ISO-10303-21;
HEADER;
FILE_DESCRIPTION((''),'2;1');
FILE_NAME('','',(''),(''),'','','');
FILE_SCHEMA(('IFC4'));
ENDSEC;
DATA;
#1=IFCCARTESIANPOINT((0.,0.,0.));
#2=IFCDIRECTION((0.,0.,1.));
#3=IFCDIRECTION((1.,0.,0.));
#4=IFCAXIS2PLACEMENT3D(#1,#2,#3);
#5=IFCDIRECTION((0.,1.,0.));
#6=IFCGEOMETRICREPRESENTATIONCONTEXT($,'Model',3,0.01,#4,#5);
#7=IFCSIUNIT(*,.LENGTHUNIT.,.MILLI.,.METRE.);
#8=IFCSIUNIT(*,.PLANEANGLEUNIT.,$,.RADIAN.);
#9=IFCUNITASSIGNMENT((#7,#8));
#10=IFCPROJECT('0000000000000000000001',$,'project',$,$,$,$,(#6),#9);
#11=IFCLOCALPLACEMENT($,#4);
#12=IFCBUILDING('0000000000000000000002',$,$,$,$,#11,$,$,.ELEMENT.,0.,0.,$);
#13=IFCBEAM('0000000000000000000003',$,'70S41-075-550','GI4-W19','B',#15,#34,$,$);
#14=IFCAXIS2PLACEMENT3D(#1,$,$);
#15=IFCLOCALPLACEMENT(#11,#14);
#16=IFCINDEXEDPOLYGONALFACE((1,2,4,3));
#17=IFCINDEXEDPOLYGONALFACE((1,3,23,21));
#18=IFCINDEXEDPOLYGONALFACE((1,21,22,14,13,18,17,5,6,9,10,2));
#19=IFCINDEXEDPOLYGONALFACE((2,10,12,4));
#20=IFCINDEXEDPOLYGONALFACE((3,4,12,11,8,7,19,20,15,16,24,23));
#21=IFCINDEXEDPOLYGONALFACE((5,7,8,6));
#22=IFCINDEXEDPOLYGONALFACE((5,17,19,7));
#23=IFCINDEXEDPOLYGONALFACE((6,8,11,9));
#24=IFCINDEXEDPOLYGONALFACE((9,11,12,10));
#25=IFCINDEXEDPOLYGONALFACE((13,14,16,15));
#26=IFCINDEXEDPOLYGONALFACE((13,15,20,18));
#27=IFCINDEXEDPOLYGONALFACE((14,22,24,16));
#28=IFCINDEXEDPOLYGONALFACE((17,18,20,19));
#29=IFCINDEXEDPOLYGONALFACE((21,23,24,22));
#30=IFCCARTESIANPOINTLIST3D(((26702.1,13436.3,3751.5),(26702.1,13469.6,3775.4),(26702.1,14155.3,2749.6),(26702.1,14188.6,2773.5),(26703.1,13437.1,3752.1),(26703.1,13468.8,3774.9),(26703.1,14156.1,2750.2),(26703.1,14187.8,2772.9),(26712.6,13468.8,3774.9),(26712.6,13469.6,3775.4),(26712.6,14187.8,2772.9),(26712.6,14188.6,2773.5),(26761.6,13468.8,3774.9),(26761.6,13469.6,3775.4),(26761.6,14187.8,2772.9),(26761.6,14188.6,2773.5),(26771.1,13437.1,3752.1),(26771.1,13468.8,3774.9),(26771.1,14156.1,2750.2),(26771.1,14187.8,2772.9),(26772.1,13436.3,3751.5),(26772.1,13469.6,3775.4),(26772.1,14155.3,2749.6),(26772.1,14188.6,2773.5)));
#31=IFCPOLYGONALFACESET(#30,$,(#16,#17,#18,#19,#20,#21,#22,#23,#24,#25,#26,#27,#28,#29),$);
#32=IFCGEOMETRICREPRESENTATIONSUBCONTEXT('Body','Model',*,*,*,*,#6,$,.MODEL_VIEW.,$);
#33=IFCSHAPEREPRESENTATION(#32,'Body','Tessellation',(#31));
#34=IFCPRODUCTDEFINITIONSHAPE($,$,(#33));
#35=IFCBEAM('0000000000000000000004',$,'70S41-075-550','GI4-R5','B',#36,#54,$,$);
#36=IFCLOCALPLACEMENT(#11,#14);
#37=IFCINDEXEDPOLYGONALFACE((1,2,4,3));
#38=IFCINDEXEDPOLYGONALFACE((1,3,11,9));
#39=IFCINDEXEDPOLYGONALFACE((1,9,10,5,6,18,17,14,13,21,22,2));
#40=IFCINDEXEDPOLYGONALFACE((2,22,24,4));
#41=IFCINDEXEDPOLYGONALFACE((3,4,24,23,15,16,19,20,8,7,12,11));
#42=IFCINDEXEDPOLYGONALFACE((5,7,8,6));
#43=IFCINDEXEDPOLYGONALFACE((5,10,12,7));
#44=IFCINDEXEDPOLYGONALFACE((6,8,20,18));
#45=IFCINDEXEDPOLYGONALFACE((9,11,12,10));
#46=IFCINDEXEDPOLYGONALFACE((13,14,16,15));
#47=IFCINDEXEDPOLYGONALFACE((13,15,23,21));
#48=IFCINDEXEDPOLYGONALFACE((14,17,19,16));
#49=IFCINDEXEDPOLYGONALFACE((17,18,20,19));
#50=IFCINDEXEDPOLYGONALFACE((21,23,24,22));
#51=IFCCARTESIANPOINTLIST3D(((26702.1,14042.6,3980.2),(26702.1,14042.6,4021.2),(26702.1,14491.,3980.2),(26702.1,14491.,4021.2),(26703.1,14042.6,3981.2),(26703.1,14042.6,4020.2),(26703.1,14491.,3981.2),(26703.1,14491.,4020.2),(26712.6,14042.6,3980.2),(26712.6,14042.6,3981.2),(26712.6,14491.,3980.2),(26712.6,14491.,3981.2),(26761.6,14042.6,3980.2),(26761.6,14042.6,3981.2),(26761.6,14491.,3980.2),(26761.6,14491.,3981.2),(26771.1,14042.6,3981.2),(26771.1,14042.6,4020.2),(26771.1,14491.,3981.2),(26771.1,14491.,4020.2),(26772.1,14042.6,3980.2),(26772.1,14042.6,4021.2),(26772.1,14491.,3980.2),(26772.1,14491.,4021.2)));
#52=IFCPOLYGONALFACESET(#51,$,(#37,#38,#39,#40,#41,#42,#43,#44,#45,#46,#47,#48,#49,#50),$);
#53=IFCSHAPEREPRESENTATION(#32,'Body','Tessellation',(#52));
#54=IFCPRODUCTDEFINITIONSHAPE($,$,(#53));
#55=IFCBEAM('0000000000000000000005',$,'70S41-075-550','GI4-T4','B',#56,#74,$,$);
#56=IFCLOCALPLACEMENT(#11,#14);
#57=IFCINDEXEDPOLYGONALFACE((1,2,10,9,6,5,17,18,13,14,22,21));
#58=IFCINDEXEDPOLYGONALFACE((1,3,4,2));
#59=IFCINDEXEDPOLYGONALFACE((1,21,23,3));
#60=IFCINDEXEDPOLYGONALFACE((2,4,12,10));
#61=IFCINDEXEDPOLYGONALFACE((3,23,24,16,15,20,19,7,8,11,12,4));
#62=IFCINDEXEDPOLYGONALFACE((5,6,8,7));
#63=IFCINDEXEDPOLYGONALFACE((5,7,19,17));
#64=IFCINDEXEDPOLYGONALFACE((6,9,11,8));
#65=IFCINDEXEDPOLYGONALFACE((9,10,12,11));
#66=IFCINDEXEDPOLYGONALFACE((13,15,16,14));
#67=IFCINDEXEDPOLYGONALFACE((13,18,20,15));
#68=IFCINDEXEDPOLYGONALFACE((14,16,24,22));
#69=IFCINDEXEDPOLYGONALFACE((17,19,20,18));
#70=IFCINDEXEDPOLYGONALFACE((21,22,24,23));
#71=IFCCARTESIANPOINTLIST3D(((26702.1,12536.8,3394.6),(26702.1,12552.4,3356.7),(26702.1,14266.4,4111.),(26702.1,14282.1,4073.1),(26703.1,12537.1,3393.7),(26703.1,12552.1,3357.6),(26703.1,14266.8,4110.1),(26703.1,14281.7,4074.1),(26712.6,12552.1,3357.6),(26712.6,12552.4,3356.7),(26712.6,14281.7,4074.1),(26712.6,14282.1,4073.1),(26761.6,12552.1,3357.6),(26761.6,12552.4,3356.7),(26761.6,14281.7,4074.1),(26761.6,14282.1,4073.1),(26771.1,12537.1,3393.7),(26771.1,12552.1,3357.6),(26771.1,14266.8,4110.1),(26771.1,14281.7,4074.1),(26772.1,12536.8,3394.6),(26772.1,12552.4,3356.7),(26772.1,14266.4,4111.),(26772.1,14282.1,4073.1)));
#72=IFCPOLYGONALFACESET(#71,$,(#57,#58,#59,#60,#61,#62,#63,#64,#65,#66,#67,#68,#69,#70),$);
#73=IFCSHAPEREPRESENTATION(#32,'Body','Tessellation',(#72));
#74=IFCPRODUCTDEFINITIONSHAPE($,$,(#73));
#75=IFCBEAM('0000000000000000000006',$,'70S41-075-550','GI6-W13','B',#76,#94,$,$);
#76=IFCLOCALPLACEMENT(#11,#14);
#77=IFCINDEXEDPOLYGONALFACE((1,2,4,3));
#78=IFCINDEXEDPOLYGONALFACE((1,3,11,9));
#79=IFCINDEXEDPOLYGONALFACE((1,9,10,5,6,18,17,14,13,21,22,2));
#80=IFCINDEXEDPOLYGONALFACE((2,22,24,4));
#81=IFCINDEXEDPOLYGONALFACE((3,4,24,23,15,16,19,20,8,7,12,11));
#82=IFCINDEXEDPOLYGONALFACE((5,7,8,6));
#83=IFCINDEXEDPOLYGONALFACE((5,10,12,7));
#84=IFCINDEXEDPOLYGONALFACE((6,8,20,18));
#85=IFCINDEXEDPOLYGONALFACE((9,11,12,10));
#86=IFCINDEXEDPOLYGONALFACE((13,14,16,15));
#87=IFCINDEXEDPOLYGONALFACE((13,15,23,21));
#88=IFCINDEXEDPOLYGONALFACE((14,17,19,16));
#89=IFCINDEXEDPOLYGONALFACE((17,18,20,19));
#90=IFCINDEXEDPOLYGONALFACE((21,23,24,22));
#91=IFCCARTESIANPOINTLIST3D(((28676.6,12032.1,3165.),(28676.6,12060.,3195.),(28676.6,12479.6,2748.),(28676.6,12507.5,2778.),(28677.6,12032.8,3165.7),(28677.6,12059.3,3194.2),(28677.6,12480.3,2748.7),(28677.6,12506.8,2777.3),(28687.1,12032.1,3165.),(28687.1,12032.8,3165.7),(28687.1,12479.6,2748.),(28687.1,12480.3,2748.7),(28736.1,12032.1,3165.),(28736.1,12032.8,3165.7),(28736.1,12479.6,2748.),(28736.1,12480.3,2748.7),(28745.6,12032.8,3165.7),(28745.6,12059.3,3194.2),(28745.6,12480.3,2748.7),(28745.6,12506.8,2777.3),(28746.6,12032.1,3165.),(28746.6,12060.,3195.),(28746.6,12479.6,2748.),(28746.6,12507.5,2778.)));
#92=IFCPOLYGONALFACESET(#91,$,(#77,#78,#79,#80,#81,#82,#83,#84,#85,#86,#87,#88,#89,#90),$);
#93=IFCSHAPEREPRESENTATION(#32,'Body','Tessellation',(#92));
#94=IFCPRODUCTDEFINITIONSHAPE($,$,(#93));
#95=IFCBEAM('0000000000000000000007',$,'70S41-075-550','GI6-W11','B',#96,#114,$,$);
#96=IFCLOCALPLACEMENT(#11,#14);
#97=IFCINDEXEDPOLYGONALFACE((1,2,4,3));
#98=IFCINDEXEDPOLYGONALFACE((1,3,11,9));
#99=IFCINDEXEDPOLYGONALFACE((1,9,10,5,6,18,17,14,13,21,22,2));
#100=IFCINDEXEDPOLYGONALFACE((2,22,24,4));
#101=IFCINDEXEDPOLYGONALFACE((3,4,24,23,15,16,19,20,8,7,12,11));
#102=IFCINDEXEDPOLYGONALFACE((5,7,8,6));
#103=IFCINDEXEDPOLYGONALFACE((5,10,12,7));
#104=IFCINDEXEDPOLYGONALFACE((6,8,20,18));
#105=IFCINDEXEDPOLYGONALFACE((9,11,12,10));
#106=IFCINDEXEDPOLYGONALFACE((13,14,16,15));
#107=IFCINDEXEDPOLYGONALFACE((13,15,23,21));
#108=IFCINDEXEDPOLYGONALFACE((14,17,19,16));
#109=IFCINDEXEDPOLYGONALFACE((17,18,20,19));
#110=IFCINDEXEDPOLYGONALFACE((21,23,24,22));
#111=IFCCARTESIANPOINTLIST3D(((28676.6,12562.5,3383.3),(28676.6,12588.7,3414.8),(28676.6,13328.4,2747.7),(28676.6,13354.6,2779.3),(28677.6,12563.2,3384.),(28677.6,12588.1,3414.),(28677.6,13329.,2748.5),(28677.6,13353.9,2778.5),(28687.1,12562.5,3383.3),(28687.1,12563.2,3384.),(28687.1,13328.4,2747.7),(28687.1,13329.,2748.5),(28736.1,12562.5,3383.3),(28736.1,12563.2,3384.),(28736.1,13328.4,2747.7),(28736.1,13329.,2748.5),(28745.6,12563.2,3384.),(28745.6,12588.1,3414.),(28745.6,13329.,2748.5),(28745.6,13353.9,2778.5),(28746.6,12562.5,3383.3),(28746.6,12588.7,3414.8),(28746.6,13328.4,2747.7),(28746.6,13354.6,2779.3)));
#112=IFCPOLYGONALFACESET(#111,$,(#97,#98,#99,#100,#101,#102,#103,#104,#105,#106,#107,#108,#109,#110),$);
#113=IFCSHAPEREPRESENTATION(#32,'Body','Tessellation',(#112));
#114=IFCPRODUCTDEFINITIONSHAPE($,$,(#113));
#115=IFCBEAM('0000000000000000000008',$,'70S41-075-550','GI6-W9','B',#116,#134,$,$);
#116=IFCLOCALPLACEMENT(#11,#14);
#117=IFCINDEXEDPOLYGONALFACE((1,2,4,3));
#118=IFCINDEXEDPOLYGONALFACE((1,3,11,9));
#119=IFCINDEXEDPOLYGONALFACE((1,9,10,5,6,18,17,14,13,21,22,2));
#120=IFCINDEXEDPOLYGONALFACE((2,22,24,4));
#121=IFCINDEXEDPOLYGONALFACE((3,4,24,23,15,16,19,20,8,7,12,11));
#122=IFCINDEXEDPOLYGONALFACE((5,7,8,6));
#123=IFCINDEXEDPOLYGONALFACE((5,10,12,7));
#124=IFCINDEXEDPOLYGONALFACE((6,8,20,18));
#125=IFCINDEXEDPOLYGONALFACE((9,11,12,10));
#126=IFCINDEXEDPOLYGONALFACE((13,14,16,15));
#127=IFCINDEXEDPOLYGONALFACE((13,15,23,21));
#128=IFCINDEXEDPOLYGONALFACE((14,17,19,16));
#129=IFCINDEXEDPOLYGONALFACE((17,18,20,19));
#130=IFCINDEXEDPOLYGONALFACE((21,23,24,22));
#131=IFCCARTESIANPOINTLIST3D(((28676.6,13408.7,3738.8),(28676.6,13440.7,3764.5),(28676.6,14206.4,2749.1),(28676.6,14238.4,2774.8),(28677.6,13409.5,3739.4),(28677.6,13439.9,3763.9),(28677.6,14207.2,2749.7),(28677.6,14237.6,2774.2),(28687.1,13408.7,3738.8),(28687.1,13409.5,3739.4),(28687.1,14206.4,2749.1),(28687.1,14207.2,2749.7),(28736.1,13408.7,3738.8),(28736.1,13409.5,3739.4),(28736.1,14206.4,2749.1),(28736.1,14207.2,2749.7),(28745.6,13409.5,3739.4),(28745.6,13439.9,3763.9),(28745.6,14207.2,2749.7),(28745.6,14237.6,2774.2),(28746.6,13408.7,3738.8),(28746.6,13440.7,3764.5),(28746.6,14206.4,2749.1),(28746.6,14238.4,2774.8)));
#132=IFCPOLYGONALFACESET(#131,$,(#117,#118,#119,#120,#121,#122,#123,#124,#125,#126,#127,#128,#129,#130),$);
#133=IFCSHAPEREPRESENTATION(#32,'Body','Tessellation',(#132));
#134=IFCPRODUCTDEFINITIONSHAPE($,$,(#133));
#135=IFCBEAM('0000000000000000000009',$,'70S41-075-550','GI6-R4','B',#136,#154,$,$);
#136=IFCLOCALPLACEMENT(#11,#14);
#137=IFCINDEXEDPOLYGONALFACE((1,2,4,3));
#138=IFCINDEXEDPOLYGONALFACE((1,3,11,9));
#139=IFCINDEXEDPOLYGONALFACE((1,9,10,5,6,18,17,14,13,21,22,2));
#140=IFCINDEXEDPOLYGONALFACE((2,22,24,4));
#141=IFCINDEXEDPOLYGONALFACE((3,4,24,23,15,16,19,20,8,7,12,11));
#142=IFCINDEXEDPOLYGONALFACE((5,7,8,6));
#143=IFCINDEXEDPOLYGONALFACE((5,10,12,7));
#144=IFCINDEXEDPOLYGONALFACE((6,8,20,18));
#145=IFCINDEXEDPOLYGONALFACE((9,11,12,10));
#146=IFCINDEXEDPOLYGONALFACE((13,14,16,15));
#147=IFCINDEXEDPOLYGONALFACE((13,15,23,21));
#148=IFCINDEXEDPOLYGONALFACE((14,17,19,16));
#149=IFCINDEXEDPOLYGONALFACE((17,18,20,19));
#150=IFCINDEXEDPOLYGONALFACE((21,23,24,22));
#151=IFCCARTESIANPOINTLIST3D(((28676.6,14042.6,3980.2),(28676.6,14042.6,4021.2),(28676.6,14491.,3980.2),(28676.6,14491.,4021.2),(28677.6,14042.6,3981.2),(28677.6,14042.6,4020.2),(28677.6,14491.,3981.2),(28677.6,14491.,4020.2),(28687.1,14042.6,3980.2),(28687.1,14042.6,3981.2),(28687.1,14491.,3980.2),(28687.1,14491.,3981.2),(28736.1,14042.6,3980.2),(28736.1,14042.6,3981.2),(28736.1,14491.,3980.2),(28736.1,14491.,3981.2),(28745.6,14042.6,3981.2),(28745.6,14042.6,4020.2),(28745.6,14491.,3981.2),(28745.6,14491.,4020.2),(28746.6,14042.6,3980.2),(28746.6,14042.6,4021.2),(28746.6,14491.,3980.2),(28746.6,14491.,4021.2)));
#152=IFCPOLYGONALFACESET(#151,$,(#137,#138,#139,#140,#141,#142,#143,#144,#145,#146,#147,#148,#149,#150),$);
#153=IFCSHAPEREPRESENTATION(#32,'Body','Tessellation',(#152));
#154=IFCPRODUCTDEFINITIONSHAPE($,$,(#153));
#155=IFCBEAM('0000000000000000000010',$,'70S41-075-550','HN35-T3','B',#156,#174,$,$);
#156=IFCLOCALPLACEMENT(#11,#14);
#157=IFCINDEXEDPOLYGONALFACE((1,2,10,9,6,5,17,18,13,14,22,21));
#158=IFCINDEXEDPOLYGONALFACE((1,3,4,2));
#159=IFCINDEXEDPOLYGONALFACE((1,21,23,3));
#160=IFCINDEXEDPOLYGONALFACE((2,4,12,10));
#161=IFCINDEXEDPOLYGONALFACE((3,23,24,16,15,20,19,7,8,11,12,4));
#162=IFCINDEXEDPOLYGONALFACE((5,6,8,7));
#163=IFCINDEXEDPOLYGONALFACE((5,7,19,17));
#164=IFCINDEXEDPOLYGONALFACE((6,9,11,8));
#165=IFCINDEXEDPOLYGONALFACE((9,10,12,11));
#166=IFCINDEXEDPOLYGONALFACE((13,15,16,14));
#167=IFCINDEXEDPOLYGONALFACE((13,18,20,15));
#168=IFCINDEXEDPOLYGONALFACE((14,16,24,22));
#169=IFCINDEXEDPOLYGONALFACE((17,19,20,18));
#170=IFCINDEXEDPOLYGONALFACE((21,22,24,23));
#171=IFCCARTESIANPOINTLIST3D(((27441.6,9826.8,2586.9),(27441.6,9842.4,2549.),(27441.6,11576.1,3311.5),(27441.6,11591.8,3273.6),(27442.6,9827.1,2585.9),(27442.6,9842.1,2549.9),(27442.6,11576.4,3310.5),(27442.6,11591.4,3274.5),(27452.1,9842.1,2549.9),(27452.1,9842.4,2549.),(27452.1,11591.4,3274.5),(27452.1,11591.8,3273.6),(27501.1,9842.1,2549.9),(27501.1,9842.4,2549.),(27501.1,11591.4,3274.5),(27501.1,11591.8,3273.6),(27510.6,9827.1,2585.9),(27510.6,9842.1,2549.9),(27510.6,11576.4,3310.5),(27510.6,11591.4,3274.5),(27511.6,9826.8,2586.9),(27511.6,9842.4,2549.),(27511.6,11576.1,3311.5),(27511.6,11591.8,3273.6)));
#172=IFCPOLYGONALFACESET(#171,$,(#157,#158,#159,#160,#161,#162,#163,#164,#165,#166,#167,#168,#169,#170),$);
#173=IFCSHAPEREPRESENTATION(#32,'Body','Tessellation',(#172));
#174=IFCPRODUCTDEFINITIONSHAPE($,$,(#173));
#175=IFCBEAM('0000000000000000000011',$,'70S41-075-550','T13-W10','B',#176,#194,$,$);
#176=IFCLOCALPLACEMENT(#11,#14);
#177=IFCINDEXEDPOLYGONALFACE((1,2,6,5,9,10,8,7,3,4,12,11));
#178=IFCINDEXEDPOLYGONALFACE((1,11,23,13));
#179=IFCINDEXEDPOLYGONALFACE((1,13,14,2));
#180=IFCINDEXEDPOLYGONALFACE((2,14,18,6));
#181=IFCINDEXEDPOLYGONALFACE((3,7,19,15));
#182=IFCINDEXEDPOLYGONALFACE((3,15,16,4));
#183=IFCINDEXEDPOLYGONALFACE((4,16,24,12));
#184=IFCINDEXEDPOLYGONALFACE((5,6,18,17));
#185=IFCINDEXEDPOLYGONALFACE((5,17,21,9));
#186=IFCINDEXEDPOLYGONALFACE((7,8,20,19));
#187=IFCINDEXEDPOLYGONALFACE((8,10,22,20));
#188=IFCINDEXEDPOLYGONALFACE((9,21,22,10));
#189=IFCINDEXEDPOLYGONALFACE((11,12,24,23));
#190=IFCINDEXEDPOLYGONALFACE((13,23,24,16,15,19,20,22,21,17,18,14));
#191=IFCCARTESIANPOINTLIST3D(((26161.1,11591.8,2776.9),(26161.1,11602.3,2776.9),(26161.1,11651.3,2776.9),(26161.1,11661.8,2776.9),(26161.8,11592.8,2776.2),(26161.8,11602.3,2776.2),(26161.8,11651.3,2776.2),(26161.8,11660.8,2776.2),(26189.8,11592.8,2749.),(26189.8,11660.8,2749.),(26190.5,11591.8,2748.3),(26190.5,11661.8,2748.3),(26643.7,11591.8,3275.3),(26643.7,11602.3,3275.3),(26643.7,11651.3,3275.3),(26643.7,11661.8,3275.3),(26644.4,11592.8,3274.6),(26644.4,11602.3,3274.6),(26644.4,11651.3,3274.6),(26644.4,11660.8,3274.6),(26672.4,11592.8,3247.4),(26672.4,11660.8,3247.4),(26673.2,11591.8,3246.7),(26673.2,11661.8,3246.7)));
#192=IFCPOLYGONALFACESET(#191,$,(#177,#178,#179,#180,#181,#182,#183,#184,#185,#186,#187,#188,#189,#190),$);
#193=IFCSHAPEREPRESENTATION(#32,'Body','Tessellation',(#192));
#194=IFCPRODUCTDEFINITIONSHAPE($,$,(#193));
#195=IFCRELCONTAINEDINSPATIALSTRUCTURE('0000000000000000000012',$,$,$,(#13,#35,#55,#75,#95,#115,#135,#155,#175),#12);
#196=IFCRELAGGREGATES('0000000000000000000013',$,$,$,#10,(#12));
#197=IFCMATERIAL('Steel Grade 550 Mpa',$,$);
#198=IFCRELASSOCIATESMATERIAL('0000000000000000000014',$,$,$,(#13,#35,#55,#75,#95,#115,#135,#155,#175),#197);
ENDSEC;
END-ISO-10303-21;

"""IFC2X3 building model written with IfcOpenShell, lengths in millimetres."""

from ifc_helpers import new_model, si_unit, direction, frame, origin, origin_with_axes, origin_2d_with_axis, place, context, subcontext, project, spatial, c_section, extrude, source, transform, mapped, material, element, save


model = new_model("IFC2X3")

# Units and contexts
model_context = context("Model", 3, precision=0.01, world=origin_with_axes(), true_north=direction((0.0, 1.0, 0.0)))
body_context = subcontext(model_context, "Body", "Model", "MODEL_VIEW")
ifc_project = project(units=[si_unit("LENGTHUNIT", "METRE", prefix="MILLI"), si_unit("PLANEANGLEUNIT", "RADIAN")], contexts=[model_context])

# Building
building_placement = place(None, origin_with_axes())
building = spatial("IfcBuilding", under=ifc_project, at=building_placement, CompositionType="ELEMENT", ElevationOfRefHeight=0.0, ElevationOfTerrain=0.0)

# Shared definitions
ifc_material = material(Name="Steel Grade 550 Mpa")

# Beams
shared_shape_1 = source(origin(), body_context, "Body", "SweptSolid", [
    extrude(c_section(Depth=70.0, Width=41.0, WallThickness=1.0, Girth=10.5, at=origin_2d_with_axis()), origin_with_axes(), (0.0, 0.0, 1.0), 1233.2),
])
beam_1_placement = place(None, frame((26737.1, 14171.9, 2761.6), z_axis=(0.0, -0.583017, 0.81246), x_axis=(0.0, 0.81246, 0.583017)))
element("IfcBeam", 1, at=beam_1_placement, inside=building, material=ifc_material, Name="70S41-075-550", Description="GI4-W19", ObjectType="B", context=body_context, shape_type="MappedRepresentation", body=[
    mapped(shared_shape_1, transform((0.0, 0.0, 0.0), scale=1.0)),
])
shared_shape_2 = source(origin(), body_context, "Body", "SweptSolid", [
    extrude(c_section(Depth=70.0, Width=41.0, WallThickness=1.0, Girth=10.5, at=origin_2d_with_axis()), origin_with_axes(), (0.0, 0.0, 1.0), 448.4),
])
beam_2_placement = place(None, frame((26737.1, 14042.6, 4000.7), z_axis=(0.0, 1.0, 0.0), x_axis=(0.0, 0.0, -1.0)))
element("IfcBeam", 2, at=beam_2_placement, inside=building, material=ifc_material, Name="70S41-075-550", Description="GI4-R5", ObjectType="B", context=body_context, shape_type="MappedRepresentation", body=[
    mapped(shared_shape_2, transform((0.0, 0.0, 0.0), scale=1.0)),
])
shared_shape_3 = source(origin(), body_context, "Body", "SweptSolid", [
    extrude(c_section(Depth=70.0, Width=41.0, WallThickness=1.0, Girth=10.5, at=origin_2d_with_axis()), origin_with_axes(), (0.0, 0.0, 1.0), 1872.1),
])
beam_3_placement = place(None, frame((26737.1, 12544.6, 3375.6), z_axis=(0.0, 0.92388, 0.382683), x_axis=(0.0, 0.382683, -0.92388)))
element("IfcBeam", 3, at=beam_3_placement, inside=building, material=ifc_material, Name="70S41-075-550", Description="GI4-T4", ObjectType="B", context=body_context, shape_type="MappedRepresentation", body=[
    mapped(shared_shape_3, transform((0.0, 0.0, 0.0), scale=1.0)),
])
shared_shape_4 = source(origin(), body_context, "Body", "SweptSolid", [
    extrude(c_section(Depth=70.0, Width=41.0, WallThickness=1.0, Girth=10.5, at=origin_2d_with_axis()), origin_with_axes(), (0.0, 0.0, 1.0), 611.7),
])
beam_4_placement = place(None, frame((28711.6, 12046.1, 3180.0), z_axis=(0.0, 0.731615, -0.681718), x_axis=(0.0, -0.681718, -0.731615)))
element("IfcBeam", 4, at=beam_4_placement, inside=building, material=ifc_material, Name="70S41-075-550", Description="GI6-W13", ObjectType="B", context=body_context, shape_type="MappedRepresentation", body=[
    mapped(shared_shape_4, transform((0.0, 0.0, 0.0), scale=1.0)),
])
shared_shape_5 = source(origin(), body_context, "Body", "SweptSolid", [
    extrude(c_section(Depth=70.0, Width=41.0, WallThickness=1.0, Girth=10.5, at=origin_2d_with_axis()), origin_with_axes(), (0.0, 0.0, 1.0), 995.2),
])
beam_5_placement = place(None, frame((28711.6, 12575.6, 3399.0), z_axis=(0.0, 0.769521, -0.638622), x_axis=(0.0, -0.638622, -0.769521)))
element("IfcBeam", 5, at=beam_5_placement, inside=building, material=ifc_material, Name="70S41-075-550", Description="GI6-W11", ObjectType="B", context=body_context, shape_type="MappedRepresentation", body=[
    mapped(shared_shape_5, transform((0.0, 0.0, 0.0), scale=1.0)),
])
shared_shape_6 = source(origin(), body_context, "Body", "SweptSolid", [
    extrude(c_section(Depth=70.0, Width=41.0, WallThickness=1.0, Girth=10.5, at=origin_2d_with_axis()), origin_with_axes(), (0.0, 0.0, 1.0), 1271.1),
])
beam_6_placement = place(None, frame((28711.6, 13424.7, 3751.6), z_axis=(0.0, 0.627547, -0.778578), x_axis=(0.0, -0.778578, -0.627547)))
element("IfcBeam", 6, at=beam_6_placement, inside=building, material=ifc_material, Name="70S41-075-550", Description="GI6-W9", ObjectType="B", context=body_context, shape_type="MappedRepresentation", body=[
    mapped(shared_shape_6, transform((0.0, 0.0, 0.0), scale=1.0)),
])
shared_shape_7 = source(origin(), body_context, "Body", "SweptSolid", [
    extrude(c_section(Depth=70.0, Width=41.0, WallThickness=1.0, Girth=10.5, at=origin_2d_with_axis()), origin_with_axes(), (0.0, 0.0, 1.0), 448.4),
])
beam_7_placement = place(None, frame((28711.6, 14042.6, 4000.7), z_axis=(0.0, 1.0, 0.0), x_axis=(0.0, 0.0, -1.0)))
element("IfcBeam", 7, at=beam_7_placement, inside=building, material=ifc_material, Name="70S41-075-550", Description="GI6-R4", ObjectType="B", context=body_context, shape_type="MappedRepresentation", body=[
    mapped(shared_shape_7, transform((0.0, 0.0, 0.0), scale=1.0)),
])
shared_shape_8 = source(origin(), body_context, "Body", "SweptSolid", [
    extrude(c_section(Depth=70.0, Width=41.0, WallThickness=1.0, Girth=10.5, at=origin_2d_with_axis()), origin_with_axes(), (0.0, 0.0, 1.0), 1893.4),
])
beam_8_placement = place(None, frame((27476.6, 11583.9, 3292.5), z_axis=(0.0, -0.92388, -0.382683), x_axis=(0.0, 0.382683, -0.92388)))
element("IfcBeam", 8, at=beam_8_placement, inside=building, material=ifc_material, Name="70S41-075-550", Description="HN35-T3", ObjectType="B", context=body_context, shape_type="MappedRepresentation", body=[
    mapped(shared_shape_8, transform((0.0, 0.0, 0.0), scale=1.0)),
])
shared_shape_9 = source(origin(), body_context, "Body", "SweptSolid", [
    extrude(c_section(Depth=70.0, Width=41.0, WallThickness=1.0, Girth=10.5, at=origin_2d_with_axis()), origin_with_axes(), (0.0, 0.0, 1.0), 693.8),
])
beam_9_placement = place(None, frame((26658.4, 11626.8, 3261.0), z_axis=(-0.695653, 0.0, -0.718378), x_axis=(-0.718378, 0.0, 0.695653)))
element("IfcBeam", 9, at=beam_9_placement, inside=building, material=ifc_material, Name="70S41-075-550", Description="T13-W10", ObjectType="B", context=body_context, shape_type="MappedRepresentation", body=[
    mapped(shared_shape_9, transform((0.0, 0.0, 0.0), scale=1.0)),
])

save(model, "model.ifc")
